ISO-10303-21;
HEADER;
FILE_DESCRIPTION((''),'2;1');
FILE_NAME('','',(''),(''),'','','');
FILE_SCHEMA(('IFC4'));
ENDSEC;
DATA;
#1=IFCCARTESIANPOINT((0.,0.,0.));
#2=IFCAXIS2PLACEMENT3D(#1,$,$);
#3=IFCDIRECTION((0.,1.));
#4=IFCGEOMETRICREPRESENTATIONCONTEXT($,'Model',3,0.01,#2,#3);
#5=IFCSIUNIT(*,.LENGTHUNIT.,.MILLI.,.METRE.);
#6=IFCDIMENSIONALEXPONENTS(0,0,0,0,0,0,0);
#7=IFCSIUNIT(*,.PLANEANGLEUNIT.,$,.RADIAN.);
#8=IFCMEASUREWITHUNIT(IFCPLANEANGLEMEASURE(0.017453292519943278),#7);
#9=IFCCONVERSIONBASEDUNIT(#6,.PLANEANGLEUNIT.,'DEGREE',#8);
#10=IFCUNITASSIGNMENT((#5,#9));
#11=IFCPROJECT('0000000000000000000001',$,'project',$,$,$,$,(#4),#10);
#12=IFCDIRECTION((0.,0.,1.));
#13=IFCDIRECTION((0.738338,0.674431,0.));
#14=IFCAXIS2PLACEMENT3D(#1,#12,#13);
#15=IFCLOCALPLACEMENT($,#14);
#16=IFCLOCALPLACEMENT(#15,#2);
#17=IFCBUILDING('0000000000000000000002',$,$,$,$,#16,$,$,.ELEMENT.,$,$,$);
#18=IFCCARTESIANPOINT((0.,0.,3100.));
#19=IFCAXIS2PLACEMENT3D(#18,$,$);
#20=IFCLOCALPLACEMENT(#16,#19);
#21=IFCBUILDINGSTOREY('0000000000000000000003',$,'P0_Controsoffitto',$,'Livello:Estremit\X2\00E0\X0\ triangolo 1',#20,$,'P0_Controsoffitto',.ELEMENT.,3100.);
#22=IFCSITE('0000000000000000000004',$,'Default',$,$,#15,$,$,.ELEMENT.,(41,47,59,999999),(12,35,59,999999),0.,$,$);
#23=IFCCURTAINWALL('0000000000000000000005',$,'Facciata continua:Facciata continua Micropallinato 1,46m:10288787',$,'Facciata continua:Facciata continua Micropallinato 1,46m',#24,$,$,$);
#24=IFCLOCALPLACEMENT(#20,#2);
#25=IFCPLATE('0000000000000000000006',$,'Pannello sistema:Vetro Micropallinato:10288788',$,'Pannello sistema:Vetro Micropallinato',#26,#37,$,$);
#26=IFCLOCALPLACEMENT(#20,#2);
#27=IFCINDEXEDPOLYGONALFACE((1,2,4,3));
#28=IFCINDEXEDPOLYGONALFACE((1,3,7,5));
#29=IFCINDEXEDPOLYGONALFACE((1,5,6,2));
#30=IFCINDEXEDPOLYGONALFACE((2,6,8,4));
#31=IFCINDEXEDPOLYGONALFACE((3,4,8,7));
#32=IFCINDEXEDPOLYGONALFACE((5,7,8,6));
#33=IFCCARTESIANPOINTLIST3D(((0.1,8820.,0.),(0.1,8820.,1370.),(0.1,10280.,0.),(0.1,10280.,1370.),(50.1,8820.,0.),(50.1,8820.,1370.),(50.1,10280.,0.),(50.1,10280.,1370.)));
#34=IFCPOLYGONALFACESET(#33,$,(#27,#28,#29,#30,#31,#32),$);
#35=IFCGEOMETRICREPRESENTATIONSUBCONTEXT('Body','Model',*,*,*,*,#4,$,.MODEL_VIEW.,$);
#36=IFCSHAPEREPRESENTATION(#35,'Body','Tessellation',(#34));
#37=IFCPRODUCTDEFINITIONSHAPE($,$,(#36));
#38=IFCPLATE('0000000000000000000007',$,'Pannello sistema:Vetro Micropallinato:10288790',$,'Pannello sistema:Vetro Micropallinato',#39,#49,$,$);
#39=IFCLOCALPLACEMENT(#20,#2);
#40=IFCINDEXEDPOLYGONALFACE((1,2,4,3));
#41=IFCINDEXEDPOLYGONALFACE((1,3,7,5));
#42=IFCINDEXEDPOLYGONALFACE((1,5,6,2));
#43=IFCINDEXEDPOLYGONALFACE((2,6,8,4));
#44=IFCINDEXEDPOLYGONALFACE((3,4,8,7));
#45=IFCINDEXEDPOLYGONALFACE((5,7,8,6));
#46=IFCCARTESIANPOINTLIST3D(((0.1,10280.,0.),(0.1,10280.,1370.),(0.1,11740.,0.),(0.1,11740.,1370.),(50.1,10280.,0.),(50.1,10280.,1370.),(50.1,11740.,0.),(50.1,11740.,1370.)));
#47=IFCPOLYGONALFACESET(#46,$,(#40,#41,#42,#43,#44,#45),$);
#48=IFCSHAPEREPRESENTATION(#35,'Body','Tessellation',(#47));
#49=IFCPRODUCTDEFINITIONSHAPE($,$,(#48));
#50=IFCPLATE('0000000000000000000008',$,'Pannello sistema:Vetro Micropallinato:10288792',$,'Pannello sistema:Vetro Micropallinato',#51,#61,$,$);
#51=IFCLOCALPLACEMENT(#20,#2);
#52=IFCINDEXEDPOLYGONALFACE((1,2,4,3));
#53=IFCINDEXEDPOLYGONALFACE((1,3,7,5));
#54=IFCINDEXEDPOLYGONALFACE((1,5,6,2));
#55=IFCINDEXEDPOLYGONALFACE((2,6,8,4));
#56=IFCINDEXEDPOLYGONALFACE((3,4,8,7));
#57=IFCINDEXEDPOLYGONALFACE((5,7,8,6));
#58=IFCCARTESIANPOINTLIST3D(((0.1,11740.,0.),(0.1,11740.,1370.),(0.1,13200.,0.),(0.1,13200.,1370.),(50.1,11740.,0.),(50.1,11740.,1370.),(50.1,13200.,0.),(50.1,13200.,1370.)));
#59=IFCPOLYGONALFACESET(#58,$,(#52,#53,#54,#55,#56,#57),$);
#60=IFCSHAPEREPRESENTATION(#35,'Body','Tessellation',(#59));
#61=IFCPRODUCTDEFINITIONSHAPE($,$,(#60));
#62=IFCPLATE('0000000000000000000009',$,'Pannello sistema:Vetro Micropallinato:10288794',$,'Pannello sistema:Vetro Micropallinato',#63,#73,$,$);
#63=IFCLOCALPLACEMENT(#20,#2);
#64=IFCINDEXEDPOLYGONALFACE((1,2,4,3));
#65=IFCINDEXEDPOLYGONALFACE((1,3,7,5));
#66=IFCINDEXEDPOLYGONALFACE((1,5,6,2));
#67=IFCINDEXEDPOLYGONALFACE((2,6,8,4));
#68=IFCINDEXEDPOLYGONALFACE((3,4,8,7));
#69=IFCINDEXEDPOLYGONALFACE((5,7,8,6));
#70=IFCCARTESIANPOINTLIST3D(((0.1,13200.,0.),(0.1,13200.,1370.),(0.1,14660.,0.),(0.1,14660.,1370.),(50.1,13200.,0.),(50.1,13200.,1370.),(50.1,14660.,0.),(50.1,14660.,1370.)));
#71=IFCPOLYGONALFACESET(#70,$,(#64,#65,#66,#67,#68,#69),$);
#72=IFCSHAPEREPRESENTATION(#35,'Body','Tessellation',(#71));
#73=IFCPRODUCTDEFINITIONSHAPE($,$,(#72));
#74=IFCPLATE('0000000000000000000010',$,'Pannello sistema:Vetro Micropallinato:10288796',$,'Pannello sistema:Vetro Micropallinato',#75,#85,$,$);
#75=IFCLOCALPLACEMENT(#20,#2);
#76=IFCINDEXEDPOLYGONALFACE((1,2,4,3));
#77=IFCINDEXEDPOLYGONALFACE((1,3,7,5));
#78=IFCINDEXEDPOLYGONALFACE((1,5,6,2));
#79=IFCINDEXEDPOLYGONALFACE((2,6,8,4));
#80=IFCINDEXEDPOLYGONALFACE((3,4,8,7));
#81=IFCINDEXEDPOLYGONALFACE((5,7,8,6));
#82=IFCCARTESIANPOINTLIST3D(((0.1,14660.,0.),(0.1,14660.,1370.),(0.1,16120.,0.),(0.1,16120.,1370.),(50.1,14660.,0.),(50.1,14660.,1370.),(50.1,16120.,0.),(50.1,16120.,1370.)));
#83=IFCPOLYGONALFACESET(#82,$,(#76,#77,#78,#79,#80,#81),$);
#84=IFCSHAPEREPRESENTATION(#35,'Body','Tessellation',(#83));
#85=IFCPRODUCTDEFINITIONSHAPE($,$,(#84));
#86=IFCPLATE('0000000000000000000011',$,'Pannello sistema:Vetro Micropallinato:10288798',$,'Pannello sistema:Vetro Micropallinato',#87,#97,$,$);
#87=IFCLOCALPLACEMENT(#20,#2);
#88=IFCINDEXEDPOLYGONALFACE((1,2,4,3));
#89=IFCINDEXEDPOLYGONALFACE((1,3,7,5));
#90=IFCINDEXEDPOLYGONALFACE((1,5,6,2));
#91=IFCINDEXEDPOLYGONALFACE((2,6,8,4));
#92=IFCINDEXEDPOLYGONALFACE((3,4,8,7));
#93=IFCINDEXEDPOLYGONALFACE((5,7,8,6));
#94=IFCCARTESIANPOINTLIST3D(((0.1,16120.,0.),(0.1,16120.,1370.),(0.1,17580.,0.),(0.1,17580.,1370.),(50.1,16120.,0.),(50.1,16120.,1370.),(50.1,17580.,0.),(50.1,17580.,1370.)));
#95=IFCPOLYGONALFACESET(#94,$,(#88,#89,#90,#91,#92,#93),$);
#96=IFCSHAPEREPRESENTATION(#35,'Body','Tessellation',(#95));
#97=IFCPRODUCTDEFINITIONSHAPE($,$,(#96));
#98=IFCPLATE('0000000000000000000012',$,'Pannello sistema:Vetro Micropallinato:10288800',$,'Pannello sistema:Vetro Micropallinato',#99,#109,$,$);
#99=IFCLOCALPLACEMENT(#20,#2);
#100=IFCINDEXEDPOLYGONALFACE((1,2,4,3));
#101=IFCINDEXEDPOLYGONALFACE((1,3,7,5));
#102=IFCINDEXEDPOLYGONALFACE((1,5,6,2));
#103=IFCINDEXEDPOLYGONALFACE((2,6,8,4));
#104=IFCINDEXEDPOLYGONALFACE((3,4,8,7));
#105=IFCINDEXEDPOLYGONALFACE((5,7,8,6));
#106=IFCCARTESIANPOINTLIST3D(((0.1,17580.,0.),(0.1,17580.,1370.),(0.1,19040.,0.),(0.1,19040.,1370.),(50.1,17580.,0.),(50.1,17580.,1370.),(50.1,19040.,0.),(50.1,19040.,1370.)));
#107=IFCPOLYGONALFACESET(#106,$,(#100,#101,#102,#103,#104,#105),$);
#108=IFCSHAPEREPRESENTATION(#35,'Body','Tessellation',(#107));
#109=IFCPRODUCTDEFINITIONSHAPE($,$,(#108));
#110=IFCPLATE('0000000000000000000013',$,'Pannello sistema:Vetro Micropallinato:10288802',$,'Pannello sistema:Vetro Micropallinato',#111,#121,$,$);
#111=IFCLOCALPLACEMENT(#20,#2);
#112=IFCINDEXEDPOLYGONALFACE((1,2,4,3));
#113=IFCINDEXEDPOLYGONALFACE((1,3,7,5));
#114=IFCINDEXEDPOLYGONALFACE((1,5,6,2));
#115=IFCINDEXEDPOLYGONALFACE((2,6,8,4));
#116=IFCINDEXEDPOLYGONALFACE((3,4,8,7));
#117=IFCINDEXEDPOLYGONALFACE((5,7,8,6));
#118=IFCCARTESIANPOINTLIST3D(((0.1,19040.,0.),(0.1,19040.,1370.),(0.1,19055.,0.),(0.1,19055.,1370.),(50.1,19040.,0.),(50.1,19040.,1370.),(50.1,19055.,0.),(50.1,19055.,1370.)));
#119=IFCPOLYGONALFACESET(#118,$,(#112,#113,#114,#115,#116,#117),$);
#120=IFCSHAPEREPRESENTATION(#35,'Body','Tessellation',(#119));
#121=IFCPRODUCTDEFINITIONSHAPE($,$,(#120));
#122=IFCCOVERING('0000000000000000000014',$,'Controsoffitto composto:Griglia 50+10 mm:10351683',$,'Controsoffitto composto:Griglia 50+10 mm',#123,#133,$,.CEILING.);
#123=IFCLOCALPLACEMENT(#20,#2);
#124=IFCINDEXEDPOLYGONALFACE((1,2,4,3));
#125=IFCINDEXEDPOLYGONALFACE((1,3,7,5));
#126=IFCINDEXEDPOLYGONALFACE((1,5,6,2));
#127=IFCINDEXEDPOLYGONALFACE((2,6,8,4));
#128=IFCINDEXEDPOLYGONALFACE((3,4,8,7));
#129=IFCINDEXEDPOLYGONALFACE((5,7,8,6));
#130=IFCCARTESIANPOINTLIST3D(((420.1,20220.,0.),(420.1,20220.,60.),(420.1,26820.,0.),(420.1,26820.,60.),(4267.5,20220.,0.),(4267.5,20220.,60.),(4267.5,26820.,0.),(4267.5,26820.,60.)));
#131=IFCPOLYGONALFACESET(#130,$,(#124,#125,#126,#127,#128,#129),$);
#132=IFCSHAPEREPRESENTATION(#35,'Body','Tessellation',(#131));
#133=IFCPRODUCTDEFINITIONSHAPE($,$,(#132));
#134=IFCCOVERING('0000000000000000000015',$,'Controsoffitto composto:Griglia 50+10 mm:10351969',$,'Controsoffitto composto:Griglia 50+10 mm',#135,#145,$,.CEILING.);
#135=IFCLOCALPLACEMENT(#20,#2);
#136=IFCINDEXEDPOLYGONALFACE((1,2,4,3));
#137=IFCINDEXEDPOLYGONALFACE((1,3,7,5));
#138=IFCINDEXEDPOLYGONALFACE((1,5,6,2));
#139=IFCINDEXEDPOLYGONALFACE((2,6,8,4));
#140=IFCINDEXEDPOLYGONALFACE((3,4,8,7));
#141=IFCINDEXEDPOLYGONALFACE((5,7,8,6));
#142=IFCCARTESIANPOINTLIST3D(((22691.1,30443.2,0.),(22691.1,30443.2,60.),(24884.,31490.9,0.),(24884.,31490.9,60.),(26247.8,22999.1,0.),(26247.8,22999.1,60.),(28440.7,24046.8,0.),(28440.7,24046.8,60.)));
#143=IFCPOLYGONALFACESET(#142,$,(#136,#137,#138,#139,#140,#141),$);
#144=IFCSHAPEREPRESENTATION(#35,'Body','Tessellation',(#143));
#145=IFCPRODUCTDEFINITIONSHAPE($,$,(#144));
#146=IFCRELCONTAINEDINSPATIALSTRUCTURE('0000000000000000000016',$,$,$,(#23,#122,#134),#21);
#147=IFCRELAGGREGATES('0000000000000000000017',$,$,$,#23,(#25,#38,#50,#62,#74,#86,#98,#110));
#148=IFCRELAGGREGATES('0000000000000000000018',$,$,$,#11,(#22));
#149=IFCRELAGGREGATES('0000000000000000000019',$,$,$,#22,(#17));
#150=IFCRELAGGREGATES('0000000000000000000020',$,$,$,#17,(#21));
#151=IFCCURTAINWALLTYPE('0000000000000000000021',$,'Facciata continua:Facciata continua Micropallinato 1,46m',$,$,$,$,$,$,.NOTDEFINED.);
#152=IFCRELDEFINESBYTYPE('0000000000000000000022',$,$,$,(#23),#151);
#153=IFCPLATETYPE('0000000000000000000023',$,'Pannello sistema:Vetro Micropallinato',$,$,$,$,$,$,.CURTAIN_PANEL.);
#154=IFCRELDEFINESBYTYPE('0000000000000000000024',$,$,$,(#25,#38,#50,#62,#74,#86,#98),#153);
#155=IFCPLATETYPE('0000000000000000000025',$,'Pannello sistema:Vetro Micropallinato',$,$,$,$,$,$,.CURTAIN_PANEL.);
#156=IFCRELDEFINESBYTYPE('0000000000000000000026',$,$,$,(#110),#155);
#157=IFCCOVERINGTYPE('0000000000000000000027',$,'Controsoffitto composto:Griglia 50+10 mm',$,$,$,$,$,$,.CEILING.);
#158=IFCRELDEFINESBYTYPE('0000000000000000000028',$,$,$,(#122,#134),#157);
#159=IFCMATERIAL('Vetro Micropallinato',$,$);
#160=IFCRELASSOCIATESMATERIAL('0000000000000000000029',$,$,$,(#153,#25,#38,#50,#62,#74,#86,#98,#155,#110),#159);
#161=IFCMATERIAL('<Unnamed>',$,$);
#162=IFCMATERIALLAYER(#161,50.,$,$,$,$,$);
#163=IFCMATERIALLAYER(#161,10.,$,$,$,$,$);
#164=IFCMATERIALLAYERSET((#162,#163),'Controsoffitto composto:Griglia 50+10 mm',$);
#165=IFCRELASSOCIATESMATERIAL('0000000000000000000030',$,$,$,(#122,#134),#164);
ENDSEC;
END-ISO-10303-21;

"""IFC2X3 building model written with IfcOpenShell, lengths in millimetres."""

from ifc_helpers import new_model, entity, si_unit, converted_unit, direction, frame, frame_2d, origin, place, context, subcontext, project, spatial, rectangle, extrude, source, transform, mapped, material, layer, layer_set, layer_usage, type_object, type_shapes, element, aggregate, save


model = new_model("IFC2X3")

# Units and contexts
model_context = context("Model", 3, precision=0.01, world=origin(), true_north=direction((0.0, 1.0)))
body_context = subcontext(model_context, "Body", "Model", "MODEL_VIEW")
ifc_project = project(units=[si_unit("LENGTHUNIT", "METRE", prefix="MILLI"), converted_unit("PLANEANGLEUNIT", "DEGREE", entity("IfcPlaneAngleMeasure", 0.017453292519943278), si_unit("PLANEANGLEUNIT", "RADIAN"), dimensions=[0, 0, 0, 0, 0, 0, 0])], contexts=[model_context])

# Site, building, storey
site_placement = place(None, frame((0.0, 0.0, 0.0), z_axis=(0.0, 0.0, 1.0), x_axis=(0.738338, 0.674431, 0.0)))
site = spatial("IfcSite", under=ifc_project, at=site_placement, Name="Default", CompositionType="ELEMENT", RefLatitude=(41, 47, 59, 999999), RefLongitude=(12, 35, 59, 999999), RefElevation=0.0)
building_placement = place(site_placement, origin())
building = spatial("IfcBuilding", under=site, at=building_placement, CompositionType="ELEMENT")
storey_placement = place(building_placement, frame((0.0, 0.0, 3100.0)))
storey = spatial("IfcBuildingStorey", under=building, at=storey_placement, Name="P0_Controsoffitto", ObjectType="Livello:Estremità triangolo 1", LongName="P0_Controsoffitto", CompositionType="ELEMENT", Elevation=3100.0)

# Curtain wall, plates
curtain_wall_type = type_object("IfcCurtainWallType", Name="Facciata continua:Facciata continua Micropallinato 1,46m", PredefinedType="NOTDEFINED")
curtain_wall_placement = place(storey_placement, frame((0.0, 0.0, -3100.0)))
curtain_wall = element("IfcCurtainWall", 1, at=curtain_wall_placement, inside=storey, type_object=curtain_wall_type, Name="Facciata continua:Facciata continua Micropallinato 1,46m:10288787", ObjectType="Facciata continua:Facciata continua Micropallinato 1,46m")
ifc_material_1 = material(Name="Vetro Micropallinato")
plate_type_1 = type_object("IfcPlateType", Name="Pannello sistema:Vetro Micropallinato", PredefinedType="CURTAIN_PANEL", material=ifc_material_1)
shared_shape_1 = source(origin(), body_context, "Body", "SweptSolid", [
    extrude(rectangle(XDim=50.0, YDim=1460.0, at=frame_2d((0.0, 0.0), x_axis=(1.0, 0.0))), frame((0.0, -25.0, 0.0), z_axis=(0.0, 0.0, 1.0), x_axis=(0.0, 1.0, 0.0)), (0.0, 0.0, 1.0), 1370.0),
])
type_shapes(plate_type_1, [shared_shape_1])
plate_1_placement = place(curtain_wall_placement, frame((0.1, 9550.0, 3100.0), z_axis=(0.0, 0.0, 1.0), x_axis=(0.0, 1.0, 0.0)))
plate_1 = element("IfcPlate", 2, at=plate_1_placement, type_object=plate_type_1, material=ifc_material_1, Name="Pannello sistema:Vetro Micropallinato:10288788", ObjectType="Pannello sistema:Vetro Micropallinato", context=body_context, shape_type="MappedRepresentation", body=[
    mapped(shared_shape_1, transform((0.0, 0.0, 0.0), scale=1.0)),
])
plate_2_placement = place(curtain_wall_placement, frame((0.1, 11010.0, 3100.0), z_axis=(0.0, 0.0, 1.0), x_axis=(0.0, 1.0, 0.0)))
plate_2 = element("IfcPlate", 3, at=plate_2_placement, type_object=plate_type_1, material=ifc_material_1, Name="Pannello sistema:Vetro Micropallinato:10288790", ObjectType="Pannello sistema:Vetro Micropallinato", context=body_context, shape_type="MappedRepresentation", body=[
    mapped(shared_shape_1, transform((0.0, 0.0, 0.0), scale=1.0)),
])
plate_3_placement = place(curtain_wall_placement, frame((0.1, 12470.0, 3100.0), z_axis=(0.0, 0.0, 1.0), x_axis=(0.0, 1.0, 0.0)))
plate_3 = element("IfcPlate", 4, at=plate_3_placement, type_object=plate_type_1, material=ifc_material_1, Name="Pannello sistema:Vetro Micropallinato:10288792", ObjectType="Pannello sistema:Vetro Micropallinato", context=body_context, shape_type="MappedRepresentation", body=[
    mapped(shared_shape_1, transform((0.0, 0.0, 0.0), scale=1.0)),
])
plate_4_placement = place(curtain_wall_placement, frame((0.1, 13930.0, 3100.0), z_axis=(0.0, 0.0, 1.0), x_axis=(0.0, 1.0, 0.0)))
plate_4 = element("IfcPlate", 5, at=plate_4_placement, type_object=plate_type_1, material=ifc_material_1, Name="Pannello sistema:Vetro Micropallinato:10288794", ObjectType="Pannello sistema:Vetro Micropallinato", context=body_context, shape_type="MappedRepresentation", body=[
    mapped(shared_shape_1, transform((0.0, 0.0, 0.0), scale=1.0)),
])
plate_5_placement = place(curtain_wall_placement, frame((0.1, 15390.0, 3100.0), z_axis=(0.0, 0.0, 1.0), x_axis=(0.0, 1.0, 0.0)))
plate_5 = element("IfcPlate", 6, at=plate_5_placement, type_object=plate_type_1, material=ifc_material_1, Name="Pannello sistema:Vetro Micropallinato:10288796", ObjectType="Pannello sistema:Vetro Micropallinato", context=body_context, shape_type="MappedRepresentation", body=[
    mapped(shared_shape_1, transform((0.0, 0.0, 0.0), scale=1.0)),
])
plate_6_placement = place(curtain_wall_placement, frame((0.1, 16850.0, 3100.0), z_axis=(0.0, 0.0, 1.0), x_axis=(0.0, 1.0, 0.0)))
plate_6 = element("IfcPlate", 7, at=plate_6_placement, type_object=plate_type_1, material=ifc_material_1, Name="Pannello sistema:Vetro Micropallinato:10288798", ObjectType="Pannello sistema:Vetro Micropallinato", context=body_context, shape_type="MappedRepresentation", body=[
    mapped(shared_shape_1, transform((0.0, 0.0, 0.0), scale=1.0)),
])
plate_7_placement = place(curtain_wall_placement, frame((0.1, 18310.0, 3100.0), z_axis=(0.0, 0.0, 1.0), x_axis=(0.0, 1.0, 0.0)))
plate_7 = element("IfcPlate", 8, at=plate_7_placement, type_object=plate_type_1, material=ifc_material_1, Name="Pannello sistema:Vetro Micropallinato:10288800", ObjectType="Pannello sistema:Vetro Micropallinato", context=body_context, shape_type="MappedRepresentation", body=[
    mapped(shared_shape_1, transform((0.0, 0.0, 0.0), scale=1.0)),
])
plate_type_2 = type_object("IfcPlateType", Name="Pannello sistema:Vetro Micropallinato", PredefinedType="CURTAIN_PANEL", material=ifc_material_1)
shared_shape_2 = source(origin(), body_context, "Body", "SweptSolid", [
    extrude(rectangle(XDim=50.0, YDim=15.0, at=frame_2d((0.0, 0.0), x_axis=(1.0, 0.0))), frame((0.0, -25.0, 0.0), z_axis=(0.0, 0.0, 1.0), x_axis=(0.0, 1.0, 0.0)), (0.0, 0.0, 1.0), 1370.0),
])
type_shapes(plate_type_2, [shared_shape_2])
plate_8_placement = place(curtain_wall_placement, frame((0.1, 19047.5, 3100.0), z_axis=(0.0, 0.0, 1.0), x_axis=(0.0, 1.0, 0.0)))
plate_8 = element("IfcPlate", 9, at=plate_8_placement, type_object=plate_type_2, material=ifc_material_1, Name="Pannello sistema:Vetro Micropallinato:10288802", ObjectType="Pannello sistema:Vetro Micropallinato", context=body_context, shape_type="MappedRepresentation", body=[
    mapped(shared_shape_2, transform((0.0, 0.0, 0.0), scale=1.0)),
])
aggregate(curtain_wall, [plate_1, plate_2, plate_3, plate_4, plate_5, plate_6, plate_7, plate_8])

# Coverings
ifc_material_2 = material(Name="<Unnamed>")
ifc_layer_1 = layer(ifc_material_2, 50.0)
ifc_layer_2 = layer(ifc_material_2, 10.0)
ifc_layer_set = layer_set([ifc_layer_1, ifc_layer_2], Name="Controsoffitto composto:Griglia 50+10 mm")
covering_type = type_object("IfcCoveringType", Name="Controsoffitto composto:Griglia 50+10 mm", PredefinedType="CEILING")
ifc_layer_usage_1 = layer_usage(ifc_layer_set, "AXIS3", "NEGATIVE", 60.0)
covering_1_placement = place(storey_placement, origin())
element("IfcCovering", 10, at=covering_1_placement, inside=storey, type_object=covering_type, material=ifc_layer_usage_1, Name="Controsoffitto composto:Griglia 50+10 mm:10351683", ObjectType="Controsoffitto composto:Griglia 50+10 mm", PredefinedType="CEILING", context=body_context, shape_type="SweptSolid", body=[
    extrude(rectangle(XDim=6600.0, YDim=3847.4, at=frame_2d((0.0, 0.0), x_axis=(1.0, 0.0))), frame((2343.8, 23520.0, 0.0), z_axis=(0.0, 0.0, 1.0), x_axis=(0.0, -1.0, 0.0)), (0.0, 0.0, 1.0), 60.0),
])
ifc_layer_usage_2 = layer_usage(ifc_layer_set, "AXIS3", "NEGATIVE", 60.0)
covering_2_placement = place(storey_placement, origin())
element("IfcCovering", 11, at=covering_2_placement, inside=storey, type_object=covering_type, material=ifc_layer_usage_2, Name="Controsoffitto composto:Griglia 50+10 mm:10351969", ObjectType="Controsoffitto composto:Griglia 50+10 mm", PredefinedType="CEILING", context=body_context, shape_type="SweptSolid", body=[
    extrude(rectangle(XDim=2430.3, YDim=8250.1, at=frame_2d((0.0, 0.0), x_axis=(1.0, 0.0))), frame((25565.9, 27245.0, 0.0), z_axis=(0.0, 0.0, 1.0), x_axis=(-0.902302, -0.431105, 0.0)), (0.0, 0.0, 1.0), 60.0),
])

save(model, "model.ifc")
